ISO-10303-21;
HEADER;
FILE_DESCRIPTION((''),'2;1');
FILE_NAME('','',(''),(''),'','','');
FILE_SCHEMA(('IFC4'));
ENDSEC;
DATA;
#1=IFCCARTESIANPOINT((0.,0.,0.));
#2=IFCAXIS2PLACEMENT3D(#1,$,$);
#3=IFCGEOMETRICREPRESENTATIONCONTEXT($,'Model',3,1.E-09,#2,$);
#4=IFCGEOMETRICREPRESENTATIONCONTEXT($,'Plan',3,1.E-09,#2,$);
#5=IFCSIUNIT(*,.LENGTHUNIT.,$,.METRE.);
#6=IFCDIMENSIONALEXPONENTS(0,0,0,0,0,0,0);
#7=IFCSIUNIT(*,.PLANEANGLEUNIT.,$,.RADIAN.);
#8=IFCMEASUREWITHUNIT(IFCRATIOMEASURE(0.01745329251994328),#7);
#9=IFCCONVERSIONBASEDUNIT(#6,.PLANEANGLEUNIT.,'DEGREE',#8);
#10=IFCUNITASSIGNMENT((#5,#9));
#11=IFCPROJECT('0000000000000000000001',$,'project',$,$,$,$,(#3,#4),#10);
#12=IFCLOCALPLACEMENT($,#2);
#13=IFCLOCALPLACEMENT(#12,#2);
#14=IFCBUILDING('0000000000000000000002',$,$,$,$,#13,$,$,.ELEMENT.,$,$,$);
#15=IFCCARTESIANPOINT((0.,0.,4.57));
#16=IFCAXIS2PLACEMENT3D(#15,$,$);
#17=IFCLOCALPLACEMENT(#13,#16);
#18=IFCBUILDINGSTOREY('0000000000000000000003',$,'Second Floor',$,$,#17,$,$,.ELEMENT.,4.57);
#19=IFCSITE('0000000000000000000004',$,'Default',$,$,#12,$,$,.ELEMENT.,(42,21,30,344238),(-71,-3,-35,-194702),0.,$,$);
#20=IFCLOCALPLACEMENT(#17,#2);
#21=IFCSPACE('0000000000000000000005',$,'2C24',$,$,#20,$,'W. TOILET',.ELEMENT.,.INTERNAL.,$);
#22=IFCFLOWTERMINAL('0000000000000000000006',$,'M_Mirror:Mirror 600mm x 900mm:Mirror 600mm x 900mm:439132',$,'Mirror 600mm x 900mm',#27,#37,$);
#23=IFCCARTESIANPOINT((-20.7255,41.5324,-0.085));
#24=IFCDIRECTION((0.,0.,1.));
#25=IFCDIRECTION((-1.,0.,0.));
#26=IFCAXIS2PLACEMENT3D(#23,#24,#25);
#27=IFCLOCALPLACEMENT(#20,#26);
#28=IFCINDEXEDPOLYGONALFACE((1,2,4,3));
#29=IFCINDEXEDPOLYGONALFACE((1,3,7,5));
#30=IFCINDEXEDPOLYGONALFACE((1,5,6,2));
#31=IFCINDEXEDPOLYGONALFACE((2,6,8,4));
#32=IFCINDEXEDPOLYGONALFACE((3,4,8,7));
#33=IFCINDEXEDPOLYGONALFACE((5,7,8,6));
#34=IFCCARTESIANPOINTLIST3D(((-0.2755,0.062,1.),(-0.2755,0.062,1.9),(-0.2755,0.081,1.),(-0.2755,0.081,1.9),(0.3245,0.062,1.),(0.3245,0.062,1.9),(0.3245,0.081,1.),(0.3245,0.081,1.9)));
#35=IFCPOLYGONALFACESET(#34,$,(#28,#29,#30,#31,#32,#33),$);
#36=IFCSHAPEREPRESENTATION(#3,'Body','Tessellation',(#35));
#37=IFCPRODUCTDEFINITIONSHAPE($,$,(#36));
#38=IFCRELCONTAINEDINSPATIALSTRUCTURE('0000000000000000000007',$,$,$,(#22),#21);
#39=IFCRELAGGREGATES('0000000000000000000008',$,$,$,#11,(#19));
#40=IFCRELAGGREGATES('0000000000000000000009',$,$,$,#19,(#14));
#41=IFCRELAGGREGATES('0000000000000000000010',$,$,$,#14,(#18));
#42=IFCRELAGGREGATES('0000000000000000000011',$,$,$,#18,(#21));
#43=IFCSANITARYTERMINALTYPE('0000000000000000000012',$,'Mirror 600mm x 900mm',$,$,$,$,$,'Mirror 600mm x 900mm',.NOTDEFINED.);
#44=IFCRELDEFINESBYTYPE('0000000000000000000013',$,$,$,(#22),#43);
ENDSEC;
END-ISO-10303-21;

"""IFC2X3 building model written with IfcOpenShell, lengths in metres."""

from ifc_helpers import new_model, entity, si_unit, converted_unit, frame, origin, origin_2d_with_axis, place, context, project, spatial, rectangle, extrude, source, transform, mapped, type_object, type_shapes, element, save


model = new_model("IFC2X3")

# Units and contexts
model_context = context("Model", 3, precision=1e-09, world=origin())
plan_context = context("Plan", 3, precision=1e-09, world=origin())
ifc_project = project(units=[si_unit("LENGTHUNIT", "METRE"), converted_unit("PLANEANGLEUNIT", "DEGREE", entity("IfcRatioMeasure", 0.01745329251994328), si_unit("PLANEANGLEUNIT", "RADIAN"), dimensions=[0, 0, 0, 0, 0, 0, 0])], contexts=[model_context, plan_context])

# Site, building, storey
site_placement = place(None, origin())
site = spatial("IfcSite", under=ifc_project, at=site_placement, Name="Default", CompositionType="ELEMENT", RefLatitude=(42, 21, 30, 344238), RefLongitude=(-71, -3, -35, -194702), RefElevation=0.0)
building_placement = place(site_placement, origin())
building = spatial("IfcBuilding", under=site, at=building_placement, CompositionType="ELEMENT")
storey_placement = place(building_placement, frame((0.0, 0.0, 4.57)))
storey = spatial("IfcBuildingStorey", under=building, at=storey_placement, Name="Second Floor", CompositionType="ELEMENT", Elevation=4.57)

# Shared definitions
space_1_placement = place(storey_placement, origin())
space_1 = spatial("IfcSpace", under=storey, at=space_1_placement, Name="2C24", LongName="W. TOILET", CompositionType="ELEMENT", InteriorOrExteriorSpace="INTERNAL")

# Flow terminal
sanitary_terminal_type = type_object("IfcSanitaryTerminalType", Name="Mirror 600mm x 900mm", ElementType="Mirror 600mm x 900mm", PredefinedType="NOTDEFINED")
shared_shape_1 = source(origin(), model_context, "Body", "SweptSolid", [
    extrude(rectangle(XDim=0.0191, YDim=0.6, at=origin_2d_with_axis()), frame((0.0245, 0.0715, 1.0), z_axis=(0.0, 0.0, 1.0), x_axis=(0.0, -1.0, 0.0)), (0.0, 0.0, 1.0), 0.9),
])
type_shapes(sanitary_terminal_type, [shared_shape_1])
flow_terminal_placement = place(space_1_placement, frame((-20.7255, 41.5324, -0.085), z_axis=(0.0, 0.0, 1.0), x_axis=(-1.0, 0.0, 0.0)))
element("IfcFlowTerminal", 1, at=flow_terminal_placement, inside=space_1, type_object=sanitary_terminal_type, Name="M_Mirror:Mirror 600mm x 900mm:Mirror 600mm x 900mm:439132", ObjectType="Mirror 600mm x 900mm", context=model_context, shape_type="MappedRepresentation", body=[
    mapped(shared_shape_1, transform((0.0, 0.0, 0.0), scale=1.0)),
])

save(model, "model.ifc")
